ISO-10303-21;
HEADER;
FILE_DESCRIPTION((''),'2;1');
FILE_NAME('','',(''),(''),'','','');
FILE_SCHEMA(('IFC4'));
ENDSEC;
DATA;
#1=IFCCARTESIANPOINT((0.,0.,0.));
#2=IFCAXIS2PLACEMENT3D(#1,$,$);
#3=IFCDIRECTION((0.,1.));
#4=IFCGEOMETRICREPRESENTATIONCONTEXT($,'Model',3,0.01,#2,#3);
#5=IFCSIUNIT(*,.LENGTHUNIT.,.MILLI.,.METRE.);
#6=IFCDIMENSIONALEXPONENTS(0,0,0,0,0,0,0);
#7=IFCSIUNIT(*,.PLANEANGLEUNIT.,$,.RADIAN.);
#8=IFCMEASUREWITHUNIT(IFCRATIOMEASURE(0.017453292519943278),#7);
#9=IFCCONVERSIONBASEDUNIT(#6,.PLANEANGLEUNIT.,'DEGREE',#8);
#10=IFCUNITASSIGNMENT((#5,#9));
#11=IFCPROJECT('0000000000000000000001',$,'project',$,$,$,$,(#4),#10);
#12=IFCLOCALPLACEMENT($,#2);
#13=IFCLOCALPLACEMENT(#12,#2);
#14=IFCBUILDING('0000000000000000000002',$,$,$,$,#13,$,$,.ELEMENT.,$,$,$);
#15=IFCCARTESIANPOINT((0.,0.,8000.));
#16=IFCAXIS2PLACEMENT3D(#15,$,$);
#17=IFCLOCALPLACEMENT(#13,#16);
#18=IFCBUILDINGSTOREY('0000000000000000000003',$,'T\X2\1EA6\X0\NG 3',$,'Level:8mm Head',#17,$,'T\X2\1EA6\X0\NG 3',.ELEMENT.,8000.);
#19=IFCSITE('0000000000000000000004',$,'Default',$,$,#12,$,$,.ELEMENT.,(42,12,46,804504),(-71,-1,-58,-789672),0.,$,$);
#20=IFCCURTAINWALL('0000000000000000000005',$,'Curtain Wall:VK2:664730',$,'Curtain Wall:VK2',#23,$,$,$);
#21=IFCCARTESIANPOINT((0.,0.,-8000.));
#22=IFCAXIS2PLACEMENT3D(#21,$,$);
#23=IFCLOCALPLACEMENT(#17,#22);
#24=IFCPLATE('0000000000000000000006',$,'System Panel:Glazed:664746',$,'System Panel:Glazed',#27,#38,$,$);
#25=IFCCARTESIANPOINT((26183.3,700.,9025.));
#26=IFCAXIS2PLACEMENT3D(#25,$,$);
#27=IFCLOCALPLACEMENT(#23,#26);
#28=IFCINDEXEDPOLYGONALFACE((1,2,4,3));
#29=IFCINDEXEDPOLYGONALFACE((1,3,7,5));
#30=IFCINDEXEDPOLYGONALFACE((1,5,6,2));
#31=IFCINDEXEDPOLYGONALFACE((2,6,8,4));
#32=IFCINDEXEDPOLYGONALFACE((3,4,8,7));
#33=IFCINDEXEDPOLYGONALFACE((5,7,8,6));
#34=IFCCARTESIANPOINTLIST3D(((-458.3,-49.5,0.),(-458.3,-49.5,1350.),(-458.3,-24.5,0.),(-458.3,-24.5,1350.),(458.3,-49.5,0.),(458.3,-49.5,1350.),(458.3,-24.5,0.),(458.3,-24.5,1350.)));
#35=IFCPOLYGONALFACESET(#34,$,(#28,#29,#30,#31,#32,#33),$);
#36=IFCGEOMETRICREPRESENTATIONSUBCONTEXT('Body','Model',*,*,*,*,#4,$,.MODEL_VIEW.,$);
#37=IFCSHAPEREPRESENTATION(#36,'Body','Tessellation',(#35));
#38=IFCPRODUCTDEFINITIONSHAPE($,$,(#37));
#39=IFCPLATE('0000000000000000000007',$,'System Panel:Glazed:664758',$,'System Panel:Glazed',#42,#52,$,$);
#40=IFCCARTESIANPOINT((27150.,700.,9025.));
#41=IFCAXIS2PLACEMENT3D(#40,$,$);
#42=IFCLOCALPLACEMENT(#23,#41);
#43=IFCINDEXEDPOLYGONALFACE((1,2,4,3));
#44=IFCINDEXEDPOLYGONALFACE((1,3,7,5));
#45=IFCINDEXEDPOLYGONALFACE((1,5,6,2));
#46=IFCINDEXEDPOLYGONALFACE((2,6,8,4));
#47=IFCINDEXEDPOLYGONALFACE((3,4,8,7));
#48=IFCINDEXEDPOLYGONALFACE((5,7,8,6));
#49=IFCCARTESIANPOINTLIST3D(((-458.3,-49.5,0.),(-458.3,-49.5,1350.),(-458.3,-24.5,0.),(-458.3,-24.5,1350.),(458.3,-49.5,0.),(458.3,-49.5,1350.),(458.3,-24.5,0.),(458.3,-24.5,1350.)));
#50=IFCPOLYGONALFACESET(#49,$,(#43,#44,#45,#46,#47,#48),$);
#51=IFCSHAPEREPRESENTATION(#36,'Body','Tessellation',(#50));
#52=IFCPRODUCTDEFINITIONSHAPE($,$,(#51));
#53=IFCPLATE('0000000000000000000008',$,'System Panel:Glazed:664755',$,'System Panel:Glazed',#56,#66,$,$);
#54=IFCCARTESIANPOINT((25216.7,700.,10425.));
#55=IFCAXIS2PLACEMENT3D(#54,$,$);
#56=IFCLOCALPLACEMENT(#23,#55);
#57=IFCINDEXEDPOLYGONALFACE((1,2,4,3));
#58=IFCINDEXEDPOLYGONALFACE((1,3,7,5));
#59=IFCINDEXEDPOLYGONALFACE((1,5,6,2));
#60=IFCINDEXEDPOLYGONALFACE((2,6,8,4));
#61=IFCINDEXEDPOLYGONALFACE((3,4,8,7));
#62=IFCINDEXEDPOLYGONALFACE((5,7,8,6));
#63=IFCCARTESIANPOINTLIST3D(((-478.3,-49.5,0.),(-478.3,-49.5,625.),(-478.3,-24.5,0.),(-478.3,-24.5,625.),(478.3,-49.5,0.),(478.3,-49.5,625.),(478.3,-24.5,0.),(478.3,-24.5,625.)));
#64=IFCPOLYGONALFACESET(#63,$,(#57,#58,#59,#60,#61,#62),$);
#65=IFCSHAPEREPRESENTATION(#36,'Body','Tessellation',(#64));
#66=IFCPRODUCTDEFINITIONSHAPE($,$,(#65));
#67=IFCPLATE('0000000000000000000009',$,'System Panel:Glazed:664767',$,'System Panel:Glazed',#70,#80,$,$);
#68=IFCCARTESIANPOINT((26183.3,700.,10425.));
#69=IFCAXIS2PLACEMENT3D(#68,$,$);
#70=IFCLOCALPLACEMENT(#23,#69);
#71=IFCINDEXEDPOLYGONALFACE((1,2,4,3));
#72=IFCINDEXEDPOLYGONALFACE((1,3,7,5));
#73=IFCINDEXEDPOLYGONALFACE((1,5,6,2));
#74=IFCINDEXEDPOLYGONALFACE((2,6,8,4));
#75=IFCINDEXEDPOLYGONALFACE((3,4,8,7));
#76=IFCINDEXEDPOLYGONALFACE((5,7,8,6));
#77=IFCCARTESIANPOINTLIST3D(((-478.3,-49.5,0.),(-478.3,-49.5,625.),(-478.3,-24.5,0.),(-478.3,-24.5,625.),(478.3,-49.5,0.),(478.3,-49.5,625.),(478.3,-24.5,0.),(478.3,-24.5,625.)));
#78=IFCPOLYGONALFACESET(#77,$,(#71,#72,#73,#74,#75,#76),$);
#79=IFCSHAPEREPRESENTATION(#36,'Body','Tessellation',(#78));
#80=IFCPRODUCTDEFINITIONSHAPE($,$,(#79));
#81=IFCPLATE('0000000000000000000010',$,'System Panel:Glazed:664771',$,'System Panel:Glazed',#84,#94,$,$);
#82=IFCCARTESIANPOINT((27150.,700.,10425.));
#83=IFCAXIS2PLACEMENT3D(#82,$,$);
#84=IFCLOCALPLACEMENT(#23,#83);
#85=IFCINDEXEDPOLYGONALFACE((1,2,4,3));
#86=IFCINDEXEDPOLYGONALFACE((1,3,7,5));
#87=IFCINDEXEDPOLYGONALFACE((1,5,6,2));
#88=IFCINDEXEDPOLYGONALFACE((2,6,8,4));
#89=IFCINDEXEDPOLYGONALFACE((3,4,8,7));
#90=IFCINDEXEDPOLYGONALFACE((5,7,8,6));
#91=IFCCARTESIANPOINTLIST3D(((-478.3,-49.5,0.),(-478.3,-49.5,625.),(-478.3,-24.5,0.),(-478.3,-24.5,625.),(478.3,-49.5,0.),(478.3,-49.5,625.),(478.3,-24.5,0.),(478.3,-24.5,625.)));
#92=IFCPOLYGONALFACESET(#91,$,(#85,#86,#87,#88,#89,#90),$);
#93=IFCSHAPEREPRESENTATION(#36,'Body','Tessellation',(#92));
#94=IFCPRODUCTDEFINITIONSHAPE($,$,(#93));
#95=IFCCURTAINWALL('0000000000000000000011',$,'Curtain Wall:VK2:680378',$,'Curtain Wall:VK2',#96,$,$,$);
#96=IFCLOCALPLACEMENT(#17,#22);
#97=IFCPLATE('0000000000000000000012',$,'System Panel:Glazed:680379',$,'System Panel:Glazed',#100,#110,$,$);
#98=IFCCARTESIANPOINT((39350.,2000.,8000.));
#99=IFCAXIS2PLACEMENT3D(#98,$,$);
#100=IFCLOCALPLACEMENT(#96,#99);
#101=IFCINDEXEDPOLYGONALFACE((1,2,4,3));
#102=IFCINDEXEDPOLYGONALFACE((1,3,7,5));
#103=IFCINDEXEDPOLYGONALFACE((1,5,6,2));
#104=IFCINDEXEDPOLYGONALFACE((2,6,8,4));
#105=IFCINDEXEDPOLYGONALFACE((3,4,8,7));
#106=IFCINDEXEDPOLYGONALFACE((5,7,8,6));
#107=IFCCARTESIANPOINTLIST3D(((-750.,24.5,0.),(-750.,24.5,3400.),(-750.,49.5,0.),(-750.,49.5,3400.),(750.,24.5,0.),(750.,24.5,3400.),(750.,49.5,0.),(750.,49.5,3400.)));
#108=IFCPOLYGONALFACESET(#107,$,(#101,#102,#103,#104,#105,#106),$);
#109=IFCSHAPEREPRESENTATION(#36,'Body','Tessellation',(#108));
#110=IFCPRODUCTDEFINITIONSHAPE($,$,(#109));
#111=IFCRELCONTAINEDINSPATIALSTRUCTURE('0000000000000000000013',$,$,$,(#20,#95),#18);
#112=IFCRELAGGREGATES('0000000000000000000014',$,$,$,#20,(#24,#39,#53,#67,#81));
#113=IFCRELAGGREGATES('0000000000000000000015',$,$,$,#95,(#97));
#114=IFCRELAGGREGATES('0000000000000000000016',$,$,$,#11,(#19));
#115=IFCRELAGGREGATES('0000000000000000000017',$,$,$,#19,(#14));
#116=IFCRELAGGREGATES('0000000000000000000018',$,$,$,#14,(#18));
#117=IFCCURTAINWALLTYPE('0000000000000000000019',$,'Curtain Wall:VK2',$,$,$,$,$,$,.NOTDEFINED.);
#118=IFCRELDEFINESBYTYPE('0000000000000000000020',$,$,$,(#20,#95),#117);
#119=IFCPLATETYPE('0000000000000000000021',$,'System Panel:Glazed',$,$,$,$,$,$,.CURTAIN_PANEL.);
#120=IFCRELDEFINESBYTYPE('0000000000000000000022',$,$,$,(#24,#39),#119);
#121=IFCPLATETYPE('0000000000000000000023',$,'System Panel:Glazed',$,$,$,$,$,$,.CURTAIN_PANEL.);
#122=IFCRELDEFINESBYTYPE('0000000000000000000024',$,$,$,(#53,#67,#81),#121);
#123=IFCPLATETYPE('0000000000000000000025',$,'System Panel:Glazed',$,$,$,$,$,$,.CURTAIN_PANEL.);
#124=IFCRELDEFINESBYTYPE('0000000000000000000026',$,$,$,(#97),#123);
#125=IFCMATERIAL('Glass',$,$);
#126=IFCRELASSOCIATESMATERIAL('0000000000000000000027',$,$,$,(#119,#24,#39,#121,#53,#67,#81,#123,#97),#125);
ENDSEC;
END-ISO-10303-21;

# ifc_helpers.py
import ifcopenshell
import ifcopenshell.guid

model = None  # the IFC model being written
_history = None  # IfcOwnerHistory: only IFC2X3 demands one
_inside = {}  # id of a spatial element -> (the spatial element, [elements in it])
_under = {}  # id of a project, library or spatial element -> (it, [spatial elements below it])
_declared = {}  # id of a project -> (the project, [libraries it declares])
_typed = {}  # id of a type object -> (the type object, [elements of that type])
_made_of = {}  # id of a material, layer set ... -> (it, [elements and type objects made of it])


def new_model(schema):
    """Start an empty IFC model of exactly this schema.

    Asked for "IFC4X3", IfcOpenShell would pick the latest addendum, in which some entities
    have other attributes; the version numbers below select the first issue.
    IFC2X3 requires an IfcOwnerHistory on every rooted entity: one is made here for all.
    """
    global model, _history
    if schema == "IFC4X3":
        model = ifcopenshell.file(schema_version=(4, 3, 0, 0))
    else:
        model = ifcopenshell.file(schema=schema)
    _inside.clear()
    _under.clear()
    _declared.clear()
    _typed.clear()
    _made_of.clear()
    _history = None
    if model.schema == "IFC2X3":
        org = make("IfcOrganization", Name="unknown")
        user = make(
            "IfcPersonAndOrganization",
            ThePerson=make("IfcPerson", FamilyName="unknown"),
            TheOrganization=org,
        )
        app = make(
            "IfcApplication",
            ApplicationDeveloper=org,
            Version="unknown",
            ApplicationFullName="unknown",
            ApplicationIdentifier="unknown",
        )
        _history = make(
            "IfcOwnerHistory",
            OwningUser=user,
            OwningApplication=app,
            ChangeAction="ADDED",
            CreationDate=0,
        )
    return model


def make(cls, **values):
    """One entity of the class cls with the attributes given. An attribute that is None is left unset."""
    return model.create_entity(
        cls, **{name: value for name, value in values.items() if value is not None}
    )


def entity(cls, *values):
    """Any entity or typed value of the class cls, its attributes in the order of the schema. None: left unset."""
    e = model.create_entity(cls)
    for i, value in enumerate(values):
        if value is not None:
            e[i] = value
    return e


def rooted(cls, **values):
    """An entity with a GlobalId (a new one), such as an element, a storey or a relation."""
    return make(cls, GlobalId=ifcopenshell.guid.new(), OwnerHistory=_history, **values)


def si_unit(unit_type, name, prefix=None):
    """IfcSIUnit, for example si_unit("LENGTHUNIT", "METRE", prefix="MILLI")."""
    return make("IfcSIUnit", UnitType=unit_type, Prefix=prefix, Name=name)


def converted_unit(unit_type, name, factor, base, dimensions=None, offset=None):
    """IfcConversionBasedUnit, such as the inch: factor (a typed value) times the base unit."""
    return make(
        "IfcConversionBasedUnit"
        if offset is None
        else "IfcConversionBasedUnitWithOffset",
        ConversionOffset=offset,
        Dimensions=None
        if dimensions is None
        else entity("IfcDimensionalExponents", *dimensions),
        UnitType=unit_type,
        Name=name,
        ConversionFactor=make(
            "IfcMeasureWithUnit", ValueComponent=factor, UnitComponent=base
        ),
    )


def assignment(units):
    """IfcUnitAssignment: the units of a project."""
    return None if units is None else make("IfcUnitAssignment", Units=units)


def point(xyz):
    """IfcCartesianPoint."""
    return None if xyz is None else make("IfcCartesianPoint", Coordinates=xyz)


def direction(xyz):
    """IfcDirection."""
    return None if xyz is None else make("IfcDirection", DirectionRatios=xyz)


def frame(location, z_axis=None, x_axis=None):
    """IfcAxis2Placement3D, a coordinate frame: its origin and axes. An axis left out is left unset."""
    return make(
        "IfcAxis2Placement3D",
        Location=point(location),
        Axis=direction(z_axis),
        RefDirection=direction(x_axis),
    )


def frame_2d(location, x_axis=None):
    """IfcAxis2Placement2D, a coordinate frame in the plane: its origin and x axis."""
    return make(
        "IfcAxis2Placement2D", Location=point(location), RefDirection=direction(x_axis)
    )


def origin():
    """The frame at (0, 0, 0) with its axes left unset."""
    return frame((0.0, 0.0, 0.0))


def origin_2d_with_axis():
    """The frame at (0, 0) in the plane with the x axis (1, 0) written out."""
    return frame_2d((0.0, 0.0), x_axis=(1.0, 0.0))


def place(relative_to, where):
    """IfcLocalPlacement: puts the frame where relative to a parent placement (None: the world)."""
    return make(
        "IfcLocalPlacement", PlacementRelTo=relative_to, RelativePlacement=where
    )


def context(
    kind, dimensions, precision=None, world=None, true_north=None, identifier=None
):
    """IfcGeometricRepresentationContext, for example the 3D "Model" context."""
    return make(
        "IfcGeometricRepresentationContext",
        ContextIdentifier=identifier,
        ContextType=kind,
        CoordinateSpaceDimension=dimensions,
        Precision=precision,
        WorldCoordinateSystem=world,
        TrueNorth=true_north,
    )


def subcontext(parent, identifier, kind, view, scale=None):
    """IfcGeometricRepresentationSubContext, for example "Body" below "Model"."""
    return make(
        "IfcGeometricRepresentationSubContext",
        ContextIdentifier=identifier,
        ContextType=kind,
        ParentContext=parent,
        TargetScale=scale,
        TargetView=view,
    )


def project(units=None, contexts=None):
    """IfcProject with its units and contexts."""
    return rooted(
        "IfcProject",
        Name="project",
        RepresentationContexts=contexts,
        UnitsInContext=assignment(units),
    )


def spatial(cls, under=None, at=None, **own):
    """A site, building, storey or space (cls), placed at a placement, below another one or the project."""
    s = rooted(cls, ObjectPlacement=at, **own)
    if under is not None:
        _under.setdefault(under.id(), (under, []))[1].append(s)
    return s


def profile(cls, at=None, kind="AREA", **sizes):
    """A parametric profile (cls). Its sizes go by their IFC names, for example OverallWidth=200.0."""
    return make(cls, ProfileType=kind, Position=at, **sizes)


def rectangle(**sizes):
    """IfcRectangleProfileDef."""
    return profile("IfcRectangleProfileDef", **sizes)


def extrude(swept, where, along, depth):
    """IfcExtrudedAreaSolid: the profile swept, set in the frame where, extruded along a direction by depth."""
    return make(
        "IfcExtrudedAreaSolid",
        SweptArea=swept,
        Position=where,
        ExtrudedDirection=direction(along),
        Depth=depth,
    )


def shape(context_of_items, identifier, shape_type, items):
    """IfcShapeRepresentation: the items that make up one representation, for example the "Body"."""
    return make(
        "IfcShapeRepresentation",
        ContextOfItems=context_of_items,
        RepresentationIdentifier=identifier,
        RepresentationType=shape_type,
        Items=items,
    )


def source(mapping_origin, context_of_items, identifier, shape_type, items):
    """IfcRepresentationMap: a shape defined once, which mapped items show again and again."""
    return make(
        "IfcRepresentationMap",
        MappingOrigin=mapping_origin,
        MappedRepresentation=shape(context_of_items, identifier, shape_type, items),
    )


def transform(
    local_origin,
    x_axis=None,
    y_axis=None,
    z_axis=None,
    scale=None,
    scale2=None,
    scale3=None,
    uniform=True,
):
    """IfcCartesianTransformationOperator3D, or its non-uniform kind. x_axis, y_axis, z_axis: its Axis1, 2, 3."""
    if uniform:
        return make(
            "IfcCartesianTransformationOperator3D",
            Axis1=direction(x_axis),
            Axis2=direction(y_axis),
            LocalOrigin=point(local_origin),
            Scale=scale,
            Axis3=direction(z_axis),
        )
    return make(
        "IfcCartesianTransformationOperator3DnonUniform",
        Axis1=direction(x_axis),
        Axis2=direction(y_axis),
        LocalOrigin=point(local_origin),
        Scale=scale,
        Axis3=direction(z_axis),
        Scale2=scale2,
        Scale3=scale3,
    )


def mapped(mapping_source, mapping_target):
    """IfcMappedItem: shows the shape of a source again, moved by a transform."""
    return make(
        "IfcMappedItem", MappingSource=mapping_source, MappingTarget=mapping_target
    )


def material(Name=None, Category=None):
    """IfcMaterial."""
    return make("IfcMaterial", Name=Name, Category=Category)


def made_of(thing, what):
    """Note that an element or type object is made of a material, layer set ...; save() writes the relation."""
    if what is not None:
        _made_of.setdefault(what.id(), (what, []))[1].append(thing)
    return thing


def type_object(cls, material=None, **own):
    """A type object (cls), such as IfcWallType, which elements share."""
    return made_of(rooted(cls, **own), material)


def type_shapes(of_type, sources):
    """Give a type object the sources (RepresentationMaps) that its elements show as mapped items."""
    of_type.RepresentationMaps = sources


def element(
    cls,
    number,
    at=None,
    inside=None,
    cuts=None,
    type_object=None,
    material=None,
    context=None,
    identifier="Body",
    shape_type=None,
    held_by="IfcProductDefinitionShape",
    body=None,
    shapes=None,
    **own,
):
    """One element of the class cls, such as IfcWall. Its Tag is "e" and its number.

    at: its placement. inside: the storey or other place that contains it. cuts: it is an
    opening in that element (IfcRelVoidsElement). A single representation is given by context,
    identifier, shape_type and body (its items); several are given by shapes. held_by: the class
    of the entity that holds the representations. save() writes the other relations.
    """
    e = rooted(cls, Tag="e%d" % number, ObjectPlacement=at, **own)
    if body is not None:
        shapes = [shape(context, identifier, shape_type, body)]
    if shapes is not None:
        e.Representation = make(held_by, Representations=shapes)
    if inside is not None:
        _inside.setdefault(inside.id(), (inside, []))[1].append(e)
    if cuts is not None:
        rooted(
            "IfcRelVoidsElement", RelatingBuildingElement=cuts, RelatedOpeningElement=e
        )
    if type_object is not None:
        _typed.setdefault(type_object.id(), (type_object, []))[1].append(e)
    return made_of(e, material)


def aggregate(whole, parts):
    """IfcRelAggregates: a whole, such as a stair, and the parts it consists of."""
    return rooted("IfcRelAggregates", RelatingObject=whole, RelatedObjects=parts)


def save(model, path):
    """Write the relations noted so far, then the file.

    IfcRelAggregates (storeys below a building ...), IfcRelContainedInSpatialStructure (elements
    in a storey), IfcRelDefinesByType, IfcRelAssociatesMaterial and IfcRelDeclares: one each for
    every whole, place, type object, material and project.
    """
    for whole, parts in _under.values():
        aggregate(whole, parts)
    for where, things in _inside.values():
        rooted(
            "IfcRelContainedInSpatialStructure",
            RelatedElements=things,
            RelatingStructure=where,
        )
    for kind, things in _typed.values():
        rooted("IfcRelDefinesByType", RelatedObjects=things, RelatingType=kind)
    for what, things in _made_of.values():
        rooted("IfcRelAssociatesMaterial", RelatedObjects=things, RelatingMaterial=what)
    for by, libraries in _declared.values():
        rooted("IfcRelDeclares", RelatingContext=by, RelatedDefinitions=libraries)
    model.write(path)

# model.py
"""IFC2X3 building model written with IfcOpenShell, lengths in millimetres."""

from ifc_helpers import new_model, entity, si_unit, converted_unit, direction, frame, frame_2d, origin, origin_2d_with_axis, place, context, subcontext, project, spatial, rectangle, extrude, source, transform, mapped, material, type_object, type_shapes, element, aggregate, save


model = new_model("IFC2X3")

# Units and contexts
model_context = context("Model", 3, precision=0.01, world=origin(), true_north=direction((0.0, 1.0)))
body_context = subcontext(model_context, "Body", "Model", "MODEL_VIEW")
ifc_project = project(units=[si_unit("LENGTHUNIT", "METRE", prefix="MILLI"), converted_unit("PLANEANGLEUNIT", "DEGREE", entity("IfcRatioMeasure", 0.017453292519943278), si_unit("PLANEANGLEUNIT", "RADIAN"), dimensions=[0, 0, 0, 0, 0, 0, 0])], contexts=[model_context])

# Site, building, storey
site_placement = place(None, origin())
site = spatial("IfcSite", under=ifc_project, at=site_placement, Name="Default", CompositionType="ELEMENT", RefLatitude=(42, 12, 46, 804504), RefLongitude=(-71, -1, -58, -789672), RefElevation=0.0)
building_placement = place(site_placement, origin())
building = spatial("IfcBuilding", under=site, at=building_placement, CompositionType="ELEMENT")
storey_placement = place(building_placement, frame((0.0, 0.0, 8000.0)))
storey = spatial("IfcBuildingStorey", under=building, at=storey_placement, Name="TẦNG 3", ObjectType="Level:8mm Head", LongName="TẦNG 3", CompositionType="ELEMENT", Elevation=8000.0)

# Curtain wall, plates
curtain_wall_type = type_object("IfcCurtainWallType", Name="Curtain Wall:VK2", PredefinedType="NOTDEFINED")
curtain_wall_1_placement = place(storey_placement, frame((0.0, 0.0, -8000.0)))
curtain_wall_1 = element("IfcCurtainWall", 1, at=curtain_wall_1_placement, inside=storey, type_object=curtain_wall_type, Name="Curtain Wall:VK2:664730", ObjectType="Curtain Wall:VK2")
ifc_material_1 = material(Name="Glass")
plate_type_1 = type_object("IfcPlateType", Name="System Panel:Glazed", PredefinedType="CURTAIN_PANEL", material=ifc_material_1)
shared_shape_1 = source(origin(), body_context, "Body", "SweptSolid", [
    extrude(rectangle(XDim=25.0, YDim=916.7, at=frame_2d((0.0, 0.0), x_axis=(1.0, 0.0))), frame((0.0, -37.0, 0.0), z_axis=(0.0, 0.0, 1.0), x_axis=(0.0, 1.0, 0.0)), (0.0, 0.0, 1.0), 1350.0),
])
type_shapes(plate_type_1, [shared_shape_1])
plate_1_placement = place(curtain_wall_1_placement, frame((26183.3, 700.0, 9025.0)))
plate_1 = element("IfcPlate", 2, at=plate_1_placement, type_object=plate_type_1, material=ifc_material_1, Name="System Panel:Glazed:664746", ObjectType="System Panel:Glazed", context=body_context, shape_type="MappedRepresentation", body=[
    mapped(shared_shape_1, transform((0.0, 0.0, 0.0), scale=1.0)),
])
plate_2_placement = place(curtain_wall_1_placement, frame((27150.0, 700.0, 9025.0)))
plate_2 = element("IfcPlate", 3, at=plate_2_placement, type_object=plate_type_1, material=ifc_material_1, Name="System Panel:Glazed:664758", ObjectType="System Panel:Glazed", context=body_context, shape_type="MappedRepresentation", body=[
    mapped(shared_shape_1, transform((0.0, 0.0, 0.0), scale=1.0)),
])
plate_type_2 = type_object("IfcPlateType", Name="System Panel:Glazed", PredefinedType="CURTAIN_PANEL", material=ifc_material_1)
shared_shape_2 = source(origin(), body_context, "Body", "SweptSolid", [
    extrude(rectangle(XDim=25.0, YDim=956.7, at=frame_2d((0.0, 0.0), x_axis=(1.0, 0.0))), frame((0.0, -37.0, 0.0), z_axis=(0.0, 0.0, 1.0), x_axis=(0.0, 1.0, 0.0)), (0.0, 0.0, 1.0), 625.0),
])
type_shapes(plate_type_2, [shared_shape_2])
plate_3_placement = place(curtain_wall_1_placement, frame((25216.7, 700.0, 10425.0)))
plate_3 = element("IfcPlate", 4, at=plate_3_placement, type_object=plate_type_2, material=ifc_material_1, Name="System Panel:Glazed:664755", ObjectType="System Panel:Glazed", context=body_context, shape_type="MappedRepresentation", body=[
    mapped(shared_shape_2, transform((0.0, 0.0, 0.0), scale=1.0)),
])
plate_4_placement = place(curtain_wall_1_placement, frame((26183.3, 700.0, 10425.0)))
plate_4 = element("IfcPlate", 5, at=plate_4_placement, type_object=plate_type_2, material=ifc_material_1, Name="System Panel:Glazed:664767", ObjectType="System Panel:Glazed", context=body_context, shape_type="MappedRepresentation", body=[
    mapped(shared_shape_2, transform((0.0, 0.0, 0.0), scale=1.0)),
])
plate_5_placement = place(curtain_wall_1_placement, frame((27150.0, 700.0, 10425.0)))
plate_5 = element("IfcPlate", 6, at=plate_5_placement, type_object=plate_type_2, material=ifc_material_1, Name="System Panel:Glazed:664771", ObjectType="System Panel:Glazed", context=body_context, shape_type="MappedRepresentation", body=[
    mapped(shared_shape_2, transform((0.0, 0.0, 0.0), scale=1.0)),
])
aggregate(curtain_wall_1, [plate_1, plate_2, plate_3, plate_4, plate_5])

# Curtain wall, plate
curtain_wall_2_placement = place(storey_placement, frame((0.0, 0.0, -8000.0)))
curtain_wall_2 = element("IfcCurtainWall", 7, at=curtain_wall_2_placement, inside=storey, type_object=curtain_wall_type, Name="Curtain Wall:VK2:680378", ObjectType="Curtain Wall:VK2")
plate_type_3 = type_object("IfcPlateType", Name="System Panel:Glazed", PredefinedType="CURTAIN_PANEL", material=ifc_material_1)
shared_shape_3 = source(origin(), body_context, "Body", "SweptSolid", [
    extrude(rectangle(XDim=25.0, YDim=1500.0, at=origin_2d_with_axis()), frame((0.0, 37.0, 0.0), z_axis=(0.0, 0.0, 1.0), x_axis=(0.0, 1.0, 0.0)), (0.0, 0.0, 1.0), 3400.0),
])
type_shapes(plate_type_3, [shared_shape_3])
plate_6_placement = place(curtain_wall_2_placement, frame((39350.0, 2000.0, 8000.0)))
plate_6 = element("IfcPlate", 8, at=plate_6_placement, type_object=plate_type_3, material=ifc_material_1, Name="System Panel:Glazed:680379", ObjectType="System Panel:Glazed", context=body_context, shape_type="MappedRepresentation", body=[
    mapped(shared_shape_3, transform((0.0, 0.0, 0.0), scale=1.0)),
])
aggregate(curtain_wall_2, [plate_6])

save(model, "model.ifc")
